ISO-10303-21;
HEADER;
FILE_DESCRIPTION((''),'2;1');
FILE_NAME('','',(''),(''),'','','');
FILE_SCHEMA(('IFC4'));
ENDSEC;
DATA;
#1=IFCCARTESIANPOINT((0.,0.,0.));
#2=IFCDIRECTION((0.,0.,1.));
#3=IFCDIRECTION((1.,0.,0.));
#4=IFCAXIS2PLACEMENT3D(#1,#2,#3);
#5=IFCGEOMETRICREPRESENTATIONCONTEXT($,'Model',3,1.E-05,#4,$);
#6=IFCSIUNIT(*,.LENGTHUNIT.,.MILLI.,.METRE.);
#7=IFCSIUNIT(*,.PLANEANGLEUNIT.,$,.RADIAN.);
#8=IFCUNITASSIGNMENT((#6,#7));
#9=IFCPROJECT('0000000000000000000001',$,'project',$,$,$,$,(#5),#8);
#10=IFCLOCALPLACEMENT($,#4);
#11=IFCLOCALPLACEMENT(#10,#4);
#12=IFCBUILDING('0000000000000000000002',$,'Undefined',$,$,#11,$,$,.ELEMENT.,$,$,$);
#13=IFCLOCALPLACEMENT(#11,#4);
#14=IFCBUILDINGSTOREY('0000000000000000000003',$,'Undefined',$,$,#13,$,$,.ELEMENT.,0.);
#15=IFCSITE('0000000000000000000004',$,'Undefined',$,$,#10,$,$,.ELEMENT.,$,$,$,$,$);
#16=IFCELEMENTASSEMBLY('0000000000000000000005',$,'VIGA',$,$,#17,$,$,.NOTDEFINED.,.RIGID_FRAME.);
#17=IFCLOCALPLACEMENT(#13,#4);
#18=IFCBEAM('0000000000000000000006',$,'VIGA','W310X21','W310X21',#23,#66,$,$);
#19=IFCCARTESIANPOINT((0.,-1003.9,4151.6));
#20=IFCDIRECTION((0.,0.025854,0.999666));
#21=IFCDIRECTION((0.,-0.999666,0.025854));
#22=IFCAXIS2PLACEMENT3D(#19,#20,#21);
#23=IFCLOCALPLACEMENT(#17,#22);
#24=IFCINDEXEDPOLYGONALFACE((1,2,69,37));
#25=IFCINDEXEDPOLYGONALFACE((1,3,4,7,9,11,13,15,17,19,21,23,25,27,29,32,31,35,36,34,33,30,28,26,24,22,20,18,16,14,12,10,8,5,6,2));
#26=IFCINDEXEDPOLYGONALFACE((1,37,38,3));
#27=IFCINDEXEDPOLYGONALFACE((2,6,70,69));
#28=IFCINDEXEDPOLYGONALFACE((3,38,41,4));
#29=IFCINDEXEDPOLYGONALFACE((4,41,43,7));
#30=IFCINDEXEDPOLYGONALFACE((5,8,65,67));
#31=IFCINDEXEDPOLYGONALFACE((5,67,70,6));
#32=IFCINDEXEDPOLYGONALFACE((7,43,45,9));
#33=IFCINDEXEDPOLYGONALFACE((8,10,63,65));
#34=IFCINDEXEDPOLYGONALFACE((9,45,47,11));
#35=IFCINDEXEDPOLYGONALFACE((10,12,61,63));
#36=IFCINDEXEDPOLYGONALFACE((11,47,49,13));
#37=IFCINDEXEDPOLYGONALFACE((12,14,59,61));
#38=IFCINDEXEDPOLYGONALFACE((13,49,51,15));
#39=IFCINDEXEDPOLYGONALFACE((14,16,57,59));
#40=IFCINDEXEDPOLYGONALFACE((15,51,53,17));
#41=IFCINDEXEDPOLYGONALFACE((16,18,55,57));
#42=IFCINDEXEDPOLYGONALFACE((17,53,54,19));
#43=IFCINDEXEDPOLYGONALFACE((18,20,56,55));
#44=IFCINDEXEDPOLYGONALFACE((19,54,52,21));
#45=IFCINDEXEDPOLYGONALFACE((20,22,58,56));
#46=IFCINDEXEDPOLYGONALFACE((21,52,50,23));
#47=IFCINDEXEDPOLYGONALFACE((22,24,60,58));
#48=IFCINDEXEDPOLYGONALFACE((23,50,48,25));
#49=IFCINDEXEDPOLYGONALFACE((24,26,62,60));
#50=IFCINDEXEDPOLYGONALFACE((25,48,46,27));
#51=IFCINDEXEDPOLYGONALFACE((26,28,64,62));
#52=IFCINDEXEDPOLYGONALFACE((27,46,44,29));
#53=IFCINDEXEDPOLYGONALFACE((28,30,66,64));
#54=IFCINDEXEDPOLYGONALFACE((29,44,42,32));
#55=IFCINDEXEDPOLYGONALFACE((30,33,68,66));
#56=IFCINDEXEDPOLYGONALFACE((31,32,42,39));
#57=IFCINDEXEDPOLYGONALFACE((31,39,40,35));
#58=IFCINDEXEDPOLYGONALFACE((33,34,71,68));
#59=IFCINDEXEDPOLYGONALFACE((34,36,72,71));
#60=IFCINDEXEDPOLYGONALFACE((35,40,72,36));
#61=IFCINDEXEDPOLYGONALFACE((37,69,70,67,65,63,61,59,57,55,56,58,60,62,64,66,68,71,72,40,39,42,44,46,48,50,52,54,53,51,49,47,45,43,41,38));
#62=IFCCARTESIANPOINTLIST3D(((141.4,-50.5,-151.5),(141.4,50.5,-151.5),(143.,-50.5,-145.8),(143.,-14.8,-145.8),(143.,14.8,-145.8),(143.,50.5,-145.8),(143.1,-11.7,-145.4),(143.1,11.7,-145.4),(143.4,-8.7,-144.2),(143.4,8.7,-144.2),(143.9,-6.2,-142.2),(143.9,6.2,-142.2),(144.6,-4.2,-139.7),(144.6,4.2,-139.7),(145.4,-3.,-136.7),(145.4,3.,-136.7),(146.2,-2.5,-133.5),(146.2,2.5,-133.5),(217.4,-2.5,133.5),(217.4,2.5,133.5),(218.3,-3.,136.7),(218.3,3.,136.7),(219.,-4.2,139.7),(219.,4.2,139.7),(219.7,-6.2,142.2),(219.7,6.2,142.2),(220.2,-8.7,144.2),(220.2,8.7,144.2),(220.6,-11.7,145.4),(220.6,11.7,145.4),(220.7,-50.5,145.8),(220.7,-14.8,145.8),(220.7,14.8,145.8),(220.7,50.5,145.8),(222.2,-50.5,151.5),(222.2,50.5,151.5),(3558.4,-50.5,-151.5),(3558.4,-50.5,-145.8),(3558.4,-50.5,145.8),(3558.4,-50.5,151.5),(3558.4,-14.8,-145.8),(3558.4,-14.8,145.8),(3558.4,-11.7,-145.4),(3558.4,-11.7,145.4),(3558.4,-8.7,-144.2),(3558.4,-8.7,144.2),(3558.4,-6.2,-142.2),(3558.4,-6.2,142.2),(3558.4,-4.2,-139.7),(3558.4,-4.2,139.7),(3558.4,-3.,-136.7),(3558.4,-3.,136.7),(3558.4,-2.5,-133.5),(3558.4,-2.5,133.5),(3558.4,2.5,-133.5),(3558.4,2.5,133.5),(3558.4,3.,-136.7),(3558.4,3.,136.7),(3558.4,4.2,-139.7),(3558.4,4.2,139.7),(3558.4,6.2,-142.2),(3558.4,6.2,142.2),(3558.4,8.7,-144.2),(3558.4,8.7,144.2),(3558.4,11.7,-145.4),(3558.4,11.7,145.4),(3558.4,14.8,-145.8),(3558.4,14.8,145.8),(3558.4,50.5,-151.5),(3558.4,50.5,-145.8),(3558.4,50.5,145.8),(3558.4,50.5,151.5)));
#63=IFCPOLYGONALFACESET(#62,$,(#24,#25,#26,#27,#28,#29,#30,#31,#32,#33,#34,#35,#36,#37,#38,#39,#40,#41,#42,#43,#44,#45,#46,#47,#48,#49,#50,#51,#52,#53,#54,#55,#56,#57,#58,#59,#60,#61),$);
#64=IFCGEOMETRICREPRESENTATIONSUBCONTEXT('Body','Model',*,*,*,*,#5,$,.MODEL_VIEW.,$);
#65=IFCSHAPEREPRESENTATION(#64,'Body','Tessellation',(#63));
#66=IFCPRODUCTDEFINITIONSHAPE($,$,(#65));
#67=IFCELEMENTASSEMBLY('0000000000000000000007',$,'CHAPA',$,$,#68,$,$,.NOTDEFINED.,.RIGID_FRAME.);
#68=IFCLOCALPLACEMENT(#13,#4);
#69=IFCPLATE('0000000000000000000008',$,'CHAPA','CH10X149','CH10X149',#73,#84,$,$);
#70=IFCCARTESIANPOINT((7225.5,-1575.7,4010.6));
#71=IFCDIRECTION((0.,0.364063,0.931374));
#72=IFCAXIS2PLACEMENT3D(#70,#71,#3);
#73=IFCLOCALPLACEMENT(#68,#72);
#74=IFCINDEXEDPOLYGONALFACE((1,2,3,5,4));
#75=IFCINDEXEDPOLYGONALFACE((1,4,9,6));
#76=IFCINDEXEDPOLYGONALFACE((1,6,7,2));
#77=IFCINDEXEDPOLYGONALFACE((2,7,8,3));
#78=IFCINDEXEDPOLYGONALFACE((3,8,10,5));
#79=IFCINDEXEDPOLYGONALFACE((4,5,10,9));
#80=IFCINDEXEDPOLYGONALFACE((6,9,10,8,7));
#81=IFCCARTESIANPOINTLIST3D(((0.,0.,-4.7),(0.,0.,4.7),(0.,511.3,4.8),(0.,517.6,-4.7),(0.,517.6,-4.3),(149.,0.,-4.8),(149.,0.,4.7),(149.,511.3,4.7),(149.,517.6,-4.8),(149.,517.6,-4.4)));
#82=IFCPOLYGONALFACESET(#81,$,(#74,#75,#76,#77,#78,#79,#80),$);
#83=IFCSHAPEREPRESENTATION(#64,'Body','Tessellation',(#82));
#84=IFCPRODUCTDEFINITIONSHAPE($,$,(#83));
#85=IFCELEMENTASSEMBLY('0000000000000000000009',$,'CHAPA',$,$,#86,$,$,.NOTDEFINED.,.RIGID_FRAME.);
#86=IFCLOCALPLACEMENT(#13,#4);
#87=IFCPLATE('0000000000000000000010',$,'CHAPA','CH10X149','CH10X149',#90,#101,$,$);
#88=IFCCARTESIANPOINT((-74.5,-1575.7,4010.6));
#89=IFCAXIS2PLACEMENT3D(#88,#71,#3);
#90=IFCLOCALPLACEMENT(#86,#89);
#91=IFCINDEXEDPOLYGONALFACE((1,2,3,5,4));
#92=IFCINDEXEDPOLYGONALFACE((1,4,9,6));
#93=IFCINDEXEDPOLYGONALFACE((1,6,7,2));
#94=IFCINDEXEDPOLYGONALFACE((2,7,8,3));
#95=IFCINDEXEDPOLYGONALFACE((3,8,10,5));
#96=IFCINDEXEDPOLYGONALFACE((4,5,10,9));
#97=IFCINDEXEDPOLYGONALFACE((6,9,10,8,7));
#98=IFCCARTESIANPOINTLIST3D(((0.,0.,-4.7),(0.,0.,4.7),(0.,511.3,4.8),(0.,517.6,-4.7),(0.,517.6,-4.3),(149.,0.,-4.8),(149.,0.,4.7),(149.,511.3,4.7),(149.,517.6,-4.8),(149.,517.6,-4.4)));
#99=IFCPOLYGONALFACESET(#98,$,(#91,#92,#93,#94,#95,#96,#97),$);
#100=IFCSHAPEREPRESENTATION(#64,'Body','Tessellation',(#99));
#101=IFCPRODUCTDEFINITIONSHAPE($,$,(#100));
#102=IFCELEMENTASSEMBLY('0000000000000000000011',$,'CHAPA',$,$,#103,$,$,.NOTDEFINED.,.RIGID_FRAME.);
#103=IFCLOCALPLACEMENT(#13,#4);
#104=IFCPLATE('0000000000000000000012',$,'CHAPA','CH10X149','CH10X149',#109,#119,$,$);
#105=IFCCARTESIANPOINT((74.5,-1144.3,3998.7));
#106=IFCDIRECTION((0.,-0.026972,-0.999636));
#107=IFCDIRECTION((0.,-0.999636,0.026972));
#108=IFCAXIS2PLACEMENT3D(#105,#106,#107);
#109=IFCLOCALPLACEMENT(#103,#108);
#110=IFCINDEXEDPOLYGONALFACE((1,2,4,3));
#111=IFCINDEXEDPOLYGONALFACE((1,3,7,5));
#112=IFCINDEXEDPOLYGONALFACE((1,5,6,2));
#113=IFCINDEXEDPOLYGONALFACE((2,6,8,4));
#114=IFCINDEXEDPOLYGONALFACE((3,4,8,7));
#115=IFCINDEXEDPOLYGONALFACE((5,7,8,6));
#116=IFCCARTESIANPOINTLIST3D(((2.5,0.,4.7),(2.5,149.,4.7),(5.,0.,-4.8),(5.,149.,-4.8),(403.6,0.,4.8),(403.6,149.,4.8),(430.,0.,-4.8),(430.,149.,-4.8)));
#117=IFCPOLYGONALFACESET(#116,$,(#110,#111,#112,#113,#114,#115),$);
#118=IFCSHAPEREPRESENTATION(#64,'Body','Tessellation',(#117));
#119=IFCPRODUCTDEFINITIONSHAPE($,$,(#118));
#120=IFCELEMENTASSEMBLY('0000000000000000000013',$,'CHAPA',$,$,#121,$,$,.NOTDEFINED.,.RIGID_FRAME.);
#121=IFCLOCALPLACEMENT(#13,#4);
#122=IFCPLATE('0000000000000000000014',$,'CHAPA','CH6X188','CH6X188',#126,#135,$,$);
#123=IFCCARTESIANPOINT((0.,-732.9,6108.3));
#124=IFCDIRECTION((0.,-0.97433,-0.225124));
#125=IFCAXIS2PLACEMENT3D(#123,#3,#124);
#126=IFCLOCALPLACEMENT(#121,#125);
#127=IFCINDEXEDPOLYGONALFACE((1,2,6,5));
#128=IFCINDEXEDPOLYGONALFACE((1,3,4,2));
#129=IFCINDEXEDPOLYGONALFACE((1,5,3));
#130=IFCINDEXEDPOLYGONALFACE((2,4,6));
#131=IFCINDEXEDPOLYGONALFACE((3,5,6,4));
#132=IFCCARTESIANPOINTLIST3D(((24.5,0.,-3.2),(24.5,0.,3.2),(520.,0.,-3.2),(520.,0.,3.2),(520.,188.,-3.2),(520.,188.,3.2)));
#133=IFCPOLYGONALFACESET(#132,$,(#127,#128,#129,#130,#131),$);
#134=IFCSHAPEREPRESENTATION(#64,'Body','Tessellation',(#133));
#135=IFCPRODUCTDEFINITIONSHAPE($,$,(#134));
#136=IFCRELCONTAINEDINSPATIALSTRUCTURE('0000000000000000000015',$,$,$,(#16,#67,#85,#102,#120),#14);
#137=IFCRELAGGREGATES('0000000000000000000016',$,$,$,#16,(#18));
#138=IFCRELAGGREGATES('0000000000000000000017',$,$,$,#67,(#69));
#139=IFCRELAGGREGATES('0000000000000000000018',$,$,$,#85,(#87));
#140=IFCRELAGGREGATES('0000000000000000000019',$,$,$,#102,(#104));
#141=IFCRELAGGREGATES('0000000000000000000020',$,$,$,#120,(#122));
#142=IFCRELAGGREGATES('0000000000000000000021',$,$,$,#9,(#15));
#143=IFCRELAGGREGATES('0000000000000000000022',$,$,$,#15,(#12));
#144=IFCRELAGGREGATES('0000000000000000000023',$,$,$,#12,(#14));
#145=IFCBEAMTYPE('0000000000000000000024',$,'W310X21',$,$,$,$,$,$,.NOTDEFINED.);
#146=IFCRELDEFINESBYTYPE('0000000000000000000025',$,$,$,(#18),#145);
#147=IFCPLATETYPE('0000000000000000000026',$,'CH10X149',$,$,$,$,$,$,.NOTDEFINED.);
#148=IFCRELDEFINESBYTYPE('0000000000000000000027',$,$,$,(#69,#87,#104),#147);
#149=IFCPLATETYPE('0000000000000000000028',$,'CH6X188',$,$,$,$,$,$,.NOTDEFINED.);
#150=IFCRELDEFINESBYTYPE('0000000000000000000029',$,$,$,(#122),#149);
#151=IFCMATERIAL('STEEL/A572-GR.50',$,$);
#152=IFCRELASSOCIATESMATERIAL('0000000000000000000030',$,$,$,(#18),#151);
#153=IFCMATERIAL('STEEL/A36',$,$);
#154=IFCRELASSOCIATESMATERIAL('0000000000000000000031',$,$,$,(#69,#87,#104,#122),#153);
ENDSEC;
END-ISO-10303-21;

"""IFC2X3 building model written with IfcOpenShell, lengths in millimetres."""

from ifc_helpers import new_model, si_unit, frame, origin_with_axes, origin_2d_with_axis, place, context, subcontext, project, spatial, polyline, i_section, outline, extrude, clip, halfspace, material, type_object, element, aggregate, save


model = new_model("IFC2X3")

# Units and contexts
model_context = context("Model", 3, precision=1e-05, world=origin_with_axes())
body_context = subcontext(model_context, "Body", "Model", "MODEL_VIEW")
ifc_project = project(units=[si_unit("LENGTHUNIT", "METRE", prefix="MILLI"), si_unit("PLANEANGLEUNIT", "RADIAN")], contexts=[model_context])

# Site, building, storey
site_placement = place(None, origin_with_axes())
site = spatial("IfcSite", under=ifc_project, at=site_placement, Name="Undefined", CompositionType="ELEMENT")
building_placement = place(site_placement, origin_with_axes())
building = spatial("IfcBuilding", under=site, at=building_placement, Name="Undefined", CompositionType="ELEMENT")
storey_placement = place(building_placement, origin_with_axes())
storey = spatial("IfcBuildingStorey", under=building, at=storey_placement, Name="Undefined", CompositionType="ELEMENT", Elevation=0.0)

# Element assembly, beam
ifc_material_1 = material(Name="STEEL/A572-GR.50")
assembly_1_placement = place(storey_placement, origin_with_axes())
assembly_1 = element("IfcElementAssembly", 1, at=assembly_1_placement, inside=storey, Name="VIGA", AssemblyPlace="NOTDEFINED", PredefinedType="RIGID_FRAME")
beam_type_1 = type_object("IfcBeamType", Name="W310X21", PredefinedType="NOTDEFINED")
beam_1_placement = place(assembly_1_placement, frame((0.0, -1003.9, 4151.6), z_axis=(0.0, 0.025854, 0.999666), x_axis=(0.0, -0.999666, 0.025854)))
beam_1 = element("IfcBeam", 2, at=beam_1_placement, type_object=beam_type_1, material=ifc_material_1, Name="VIGA", Description="W310X21", ObjectType="W310X21", context=body_context, shape_type="Clipping", body=[
    clip(extrude(i_section(OverallWidth=101.0, OverallDepth=303.0, WebThickness=5.1, FlangeThickness=5.7, FilletRadius=12.3, at=origin_2d_with_axis()), frame((3558.4, 0.0, 0.0), z_axis=(-1.0, 0.0, 0.0), x_axis=(0.0, -1.0, 0.0)), (0.0, 0.0, 1.0), 3558.4), halfspace(frame((141.4, 50.5, -151.7), z_axis=(-0.966259, 0.0, 0.257572), x_axis=(0.257572, 0.0, 0.966259)), False)),
])
aggregate(assembly_1, [beam_1])

# Shared definitions
ifc_material_2 = material(Name="STEEL/A36")

# Element assemblies, plates
assembly_2_placement = place(storey_placement, origin_with_axes())
assembly_2 = element("IfcElementAssembly", 3, at=assembly_2_placement, inside=storey, Name="CHAPA", AssemblyPlace="NOTDEFINED", PredefinedType="RIGID_FRAME")
plate_type_1 = type_object("IfcPlateType", Name="CH10X149", PredefinedType="NOTDEFINED")
plate_1_placement = place(assembly_2_placement, frame((7225.5, -1575.7, 4010.6), z_axis=(0.0, 0.364063, 0.931374), x_axis=(1.0, 0.0, 0.0)))
plate_1 = element("IfcPlate", 4, at=plate_1_placement, type_object=plate_type_1, material=ifc_material_2, Name="CHAPA", Description="CH10X149", ObjectType="CH10X149", context=body_context, shape_type="Clipping", body=[
    clip(extrude(outline(polyline([(0.0, 0.0), (149.0, 0.0), (149.0, 517.6), (0.0, 517.6), (0.0, 0.0)])), frame((0.0, 0.0, -4.8), z_axis=(0.0, 0.0, 1.0), x_axis=(1.0, 0.0, 0.0)), (0.0, 0.0, 1.0), 9.5), halfspace(frame((149.0, 517.9, -4.7), z_axis=(0.0, 0.821204, 0.570634), x_axis=(0.0, -0.570634, 0.821204)), False)),
])
aggregate(assembly_2, [plate_1])
assembly_3_placement = place(storey_placement, origin_with_axes())
assembly_3 = element("IfcElementAssembly", 5, at=assembly_3_placement, inside=storey, Name="CHAPA", AssemblyPlace="NOTDEFINED", PredefinedType="RIGID_FRAME")
plate_2_placement = place(assembly_3_placement, frame((-74.5, -1575.7, 4010.6), z_axis=(0.0, 0.364063, 0.931374), x_axis=(1.0, 0.0, 0.0)))
plate_2 = element("IfcPlate", 6, at=plate_2_placement, type_object=plate_type_1, material=ifc_material_2, Name="CHAPA", Description="CH10X149", ObjectType="CH10X149", context=body_context, shape_type="Clipping", body=[
    clip(extrude(outline(polyline([(0.0, 0.0), (149.0, 0.0), (149.0, 517.6), (0.0, 517.6), (0.0, 0.0)])), frame((0.0, 0.0, -4.8), z_axis=(0.0, 0.0, 1.0), x_axis=(1.0, 0.0, 0.0)), (0.0, 0.0, 1.0), 9.5), halfspace(frame((149.0, 517.9, -4.7), z_axis=(0.0, 0.821204, 0.570634), x_axis=(0.0, -0.570634, 0.821204)), False)),
])
aggregate(assembly_3, [plate_2])
assembly_4_placement = place(storey_placement, origin_with_axes())
assembly_4 = element("IfcElementAssembly", 7, at=assembly_4_placement, inside=storey, Name="CHAPA", AssemblyPlace="NOTDEFINED", PredefinedType="RIGID_FRAME")
plate_3_placement = place(assembly_4_placement, frame((74.5, -1144.3, 3998.7), z_axis=(0.0, -0.026972, -0.999636), x_axis=(0.0, -0.999636, 0.026972)))
plate_3 = element("IfcPlate", 8, at=plate_3_placement, type_object=plate_type_1, material=ifc_material_2, Name="CHAPA", Description="CH10X149", ObjectType="CH10X149", context=body_context, shape_type="Clipping", body=[
    clip(clip(extrude(outline(polyline([(0.0, 0.0), (430.0, 0.0), (430.0, 149.0), (0.0, 149.0), (0.0, 0.0)])), frame((0.0, 0.0, -4.8), z_axis=(0.0, 0.0, 1.0), x_axis=(1.0, 0.0, 0.0)), (0.0, 0.0, 1.0), 9.5), halfspace(frame((403.6, -500.0, 4.7), z_axis=(0.33881, 0.0, 0.940855), x_axis=(0.0, 1.0, 0.0)), False)), halfspace(frame((5.0, -500.0, -4.8), z_axis=(-0.965989, 0.0, -0.258583), x_axis=(0.0, 1.0, 0.0)), False)),
])
aggregate(assembly_4, [plate_3])
assembly_5_placement = place(storey_placement, origin_with_axes())
assembly_5 = element("IfcElementAssembly", 9, at=assembly_5_placement, inside=storey, Name="CHAPA", AssemblyPlace="NOTDEFINED", PredefinedType="RIGID_FRAME")
plate_type_2 = type_object("IfcPlateType", Name="CH6X188", PredefinedType="NOTDEFINED")
plate_4_placement = place(assembly_5_placement, frame((0.0, -732.9, 6108.3), z_axis=(1.0, 0.0, 0.0), x_axis=(0.0, -0.97433, -0.225124)))
plate_4 = element("IfcPlate", 10, at=plate_4_placement, type_object=plate_type_2, material=ifc_material_2, Name="CHAPA", Description="CH6X188", ObjectType="CH6X188", context=body_context, shape_type="Clipping", body=[
    clip(extrude(outline(polyline([(0.0, 0.0), (520.0, 0.0), (520.0, 191.6), (0.0, 0.0)])), frame((0.0, 0.0, -3.1), z_axis=(0.0, 0.0, 1.0), x_axis=(1.0, 0.0, 0.0)), (0.0, 0.0, 1.0), 6.3), halfspace(frame((1342.2, 500.0, 3.2), z_axis=(-0.354778, 0.934951, 0.0), x_axis=(-0.934951, -0.354778, 0.0)), False)),
])
aggregate(assembly_5, [plate_4])

save(model, "model.ifc")
